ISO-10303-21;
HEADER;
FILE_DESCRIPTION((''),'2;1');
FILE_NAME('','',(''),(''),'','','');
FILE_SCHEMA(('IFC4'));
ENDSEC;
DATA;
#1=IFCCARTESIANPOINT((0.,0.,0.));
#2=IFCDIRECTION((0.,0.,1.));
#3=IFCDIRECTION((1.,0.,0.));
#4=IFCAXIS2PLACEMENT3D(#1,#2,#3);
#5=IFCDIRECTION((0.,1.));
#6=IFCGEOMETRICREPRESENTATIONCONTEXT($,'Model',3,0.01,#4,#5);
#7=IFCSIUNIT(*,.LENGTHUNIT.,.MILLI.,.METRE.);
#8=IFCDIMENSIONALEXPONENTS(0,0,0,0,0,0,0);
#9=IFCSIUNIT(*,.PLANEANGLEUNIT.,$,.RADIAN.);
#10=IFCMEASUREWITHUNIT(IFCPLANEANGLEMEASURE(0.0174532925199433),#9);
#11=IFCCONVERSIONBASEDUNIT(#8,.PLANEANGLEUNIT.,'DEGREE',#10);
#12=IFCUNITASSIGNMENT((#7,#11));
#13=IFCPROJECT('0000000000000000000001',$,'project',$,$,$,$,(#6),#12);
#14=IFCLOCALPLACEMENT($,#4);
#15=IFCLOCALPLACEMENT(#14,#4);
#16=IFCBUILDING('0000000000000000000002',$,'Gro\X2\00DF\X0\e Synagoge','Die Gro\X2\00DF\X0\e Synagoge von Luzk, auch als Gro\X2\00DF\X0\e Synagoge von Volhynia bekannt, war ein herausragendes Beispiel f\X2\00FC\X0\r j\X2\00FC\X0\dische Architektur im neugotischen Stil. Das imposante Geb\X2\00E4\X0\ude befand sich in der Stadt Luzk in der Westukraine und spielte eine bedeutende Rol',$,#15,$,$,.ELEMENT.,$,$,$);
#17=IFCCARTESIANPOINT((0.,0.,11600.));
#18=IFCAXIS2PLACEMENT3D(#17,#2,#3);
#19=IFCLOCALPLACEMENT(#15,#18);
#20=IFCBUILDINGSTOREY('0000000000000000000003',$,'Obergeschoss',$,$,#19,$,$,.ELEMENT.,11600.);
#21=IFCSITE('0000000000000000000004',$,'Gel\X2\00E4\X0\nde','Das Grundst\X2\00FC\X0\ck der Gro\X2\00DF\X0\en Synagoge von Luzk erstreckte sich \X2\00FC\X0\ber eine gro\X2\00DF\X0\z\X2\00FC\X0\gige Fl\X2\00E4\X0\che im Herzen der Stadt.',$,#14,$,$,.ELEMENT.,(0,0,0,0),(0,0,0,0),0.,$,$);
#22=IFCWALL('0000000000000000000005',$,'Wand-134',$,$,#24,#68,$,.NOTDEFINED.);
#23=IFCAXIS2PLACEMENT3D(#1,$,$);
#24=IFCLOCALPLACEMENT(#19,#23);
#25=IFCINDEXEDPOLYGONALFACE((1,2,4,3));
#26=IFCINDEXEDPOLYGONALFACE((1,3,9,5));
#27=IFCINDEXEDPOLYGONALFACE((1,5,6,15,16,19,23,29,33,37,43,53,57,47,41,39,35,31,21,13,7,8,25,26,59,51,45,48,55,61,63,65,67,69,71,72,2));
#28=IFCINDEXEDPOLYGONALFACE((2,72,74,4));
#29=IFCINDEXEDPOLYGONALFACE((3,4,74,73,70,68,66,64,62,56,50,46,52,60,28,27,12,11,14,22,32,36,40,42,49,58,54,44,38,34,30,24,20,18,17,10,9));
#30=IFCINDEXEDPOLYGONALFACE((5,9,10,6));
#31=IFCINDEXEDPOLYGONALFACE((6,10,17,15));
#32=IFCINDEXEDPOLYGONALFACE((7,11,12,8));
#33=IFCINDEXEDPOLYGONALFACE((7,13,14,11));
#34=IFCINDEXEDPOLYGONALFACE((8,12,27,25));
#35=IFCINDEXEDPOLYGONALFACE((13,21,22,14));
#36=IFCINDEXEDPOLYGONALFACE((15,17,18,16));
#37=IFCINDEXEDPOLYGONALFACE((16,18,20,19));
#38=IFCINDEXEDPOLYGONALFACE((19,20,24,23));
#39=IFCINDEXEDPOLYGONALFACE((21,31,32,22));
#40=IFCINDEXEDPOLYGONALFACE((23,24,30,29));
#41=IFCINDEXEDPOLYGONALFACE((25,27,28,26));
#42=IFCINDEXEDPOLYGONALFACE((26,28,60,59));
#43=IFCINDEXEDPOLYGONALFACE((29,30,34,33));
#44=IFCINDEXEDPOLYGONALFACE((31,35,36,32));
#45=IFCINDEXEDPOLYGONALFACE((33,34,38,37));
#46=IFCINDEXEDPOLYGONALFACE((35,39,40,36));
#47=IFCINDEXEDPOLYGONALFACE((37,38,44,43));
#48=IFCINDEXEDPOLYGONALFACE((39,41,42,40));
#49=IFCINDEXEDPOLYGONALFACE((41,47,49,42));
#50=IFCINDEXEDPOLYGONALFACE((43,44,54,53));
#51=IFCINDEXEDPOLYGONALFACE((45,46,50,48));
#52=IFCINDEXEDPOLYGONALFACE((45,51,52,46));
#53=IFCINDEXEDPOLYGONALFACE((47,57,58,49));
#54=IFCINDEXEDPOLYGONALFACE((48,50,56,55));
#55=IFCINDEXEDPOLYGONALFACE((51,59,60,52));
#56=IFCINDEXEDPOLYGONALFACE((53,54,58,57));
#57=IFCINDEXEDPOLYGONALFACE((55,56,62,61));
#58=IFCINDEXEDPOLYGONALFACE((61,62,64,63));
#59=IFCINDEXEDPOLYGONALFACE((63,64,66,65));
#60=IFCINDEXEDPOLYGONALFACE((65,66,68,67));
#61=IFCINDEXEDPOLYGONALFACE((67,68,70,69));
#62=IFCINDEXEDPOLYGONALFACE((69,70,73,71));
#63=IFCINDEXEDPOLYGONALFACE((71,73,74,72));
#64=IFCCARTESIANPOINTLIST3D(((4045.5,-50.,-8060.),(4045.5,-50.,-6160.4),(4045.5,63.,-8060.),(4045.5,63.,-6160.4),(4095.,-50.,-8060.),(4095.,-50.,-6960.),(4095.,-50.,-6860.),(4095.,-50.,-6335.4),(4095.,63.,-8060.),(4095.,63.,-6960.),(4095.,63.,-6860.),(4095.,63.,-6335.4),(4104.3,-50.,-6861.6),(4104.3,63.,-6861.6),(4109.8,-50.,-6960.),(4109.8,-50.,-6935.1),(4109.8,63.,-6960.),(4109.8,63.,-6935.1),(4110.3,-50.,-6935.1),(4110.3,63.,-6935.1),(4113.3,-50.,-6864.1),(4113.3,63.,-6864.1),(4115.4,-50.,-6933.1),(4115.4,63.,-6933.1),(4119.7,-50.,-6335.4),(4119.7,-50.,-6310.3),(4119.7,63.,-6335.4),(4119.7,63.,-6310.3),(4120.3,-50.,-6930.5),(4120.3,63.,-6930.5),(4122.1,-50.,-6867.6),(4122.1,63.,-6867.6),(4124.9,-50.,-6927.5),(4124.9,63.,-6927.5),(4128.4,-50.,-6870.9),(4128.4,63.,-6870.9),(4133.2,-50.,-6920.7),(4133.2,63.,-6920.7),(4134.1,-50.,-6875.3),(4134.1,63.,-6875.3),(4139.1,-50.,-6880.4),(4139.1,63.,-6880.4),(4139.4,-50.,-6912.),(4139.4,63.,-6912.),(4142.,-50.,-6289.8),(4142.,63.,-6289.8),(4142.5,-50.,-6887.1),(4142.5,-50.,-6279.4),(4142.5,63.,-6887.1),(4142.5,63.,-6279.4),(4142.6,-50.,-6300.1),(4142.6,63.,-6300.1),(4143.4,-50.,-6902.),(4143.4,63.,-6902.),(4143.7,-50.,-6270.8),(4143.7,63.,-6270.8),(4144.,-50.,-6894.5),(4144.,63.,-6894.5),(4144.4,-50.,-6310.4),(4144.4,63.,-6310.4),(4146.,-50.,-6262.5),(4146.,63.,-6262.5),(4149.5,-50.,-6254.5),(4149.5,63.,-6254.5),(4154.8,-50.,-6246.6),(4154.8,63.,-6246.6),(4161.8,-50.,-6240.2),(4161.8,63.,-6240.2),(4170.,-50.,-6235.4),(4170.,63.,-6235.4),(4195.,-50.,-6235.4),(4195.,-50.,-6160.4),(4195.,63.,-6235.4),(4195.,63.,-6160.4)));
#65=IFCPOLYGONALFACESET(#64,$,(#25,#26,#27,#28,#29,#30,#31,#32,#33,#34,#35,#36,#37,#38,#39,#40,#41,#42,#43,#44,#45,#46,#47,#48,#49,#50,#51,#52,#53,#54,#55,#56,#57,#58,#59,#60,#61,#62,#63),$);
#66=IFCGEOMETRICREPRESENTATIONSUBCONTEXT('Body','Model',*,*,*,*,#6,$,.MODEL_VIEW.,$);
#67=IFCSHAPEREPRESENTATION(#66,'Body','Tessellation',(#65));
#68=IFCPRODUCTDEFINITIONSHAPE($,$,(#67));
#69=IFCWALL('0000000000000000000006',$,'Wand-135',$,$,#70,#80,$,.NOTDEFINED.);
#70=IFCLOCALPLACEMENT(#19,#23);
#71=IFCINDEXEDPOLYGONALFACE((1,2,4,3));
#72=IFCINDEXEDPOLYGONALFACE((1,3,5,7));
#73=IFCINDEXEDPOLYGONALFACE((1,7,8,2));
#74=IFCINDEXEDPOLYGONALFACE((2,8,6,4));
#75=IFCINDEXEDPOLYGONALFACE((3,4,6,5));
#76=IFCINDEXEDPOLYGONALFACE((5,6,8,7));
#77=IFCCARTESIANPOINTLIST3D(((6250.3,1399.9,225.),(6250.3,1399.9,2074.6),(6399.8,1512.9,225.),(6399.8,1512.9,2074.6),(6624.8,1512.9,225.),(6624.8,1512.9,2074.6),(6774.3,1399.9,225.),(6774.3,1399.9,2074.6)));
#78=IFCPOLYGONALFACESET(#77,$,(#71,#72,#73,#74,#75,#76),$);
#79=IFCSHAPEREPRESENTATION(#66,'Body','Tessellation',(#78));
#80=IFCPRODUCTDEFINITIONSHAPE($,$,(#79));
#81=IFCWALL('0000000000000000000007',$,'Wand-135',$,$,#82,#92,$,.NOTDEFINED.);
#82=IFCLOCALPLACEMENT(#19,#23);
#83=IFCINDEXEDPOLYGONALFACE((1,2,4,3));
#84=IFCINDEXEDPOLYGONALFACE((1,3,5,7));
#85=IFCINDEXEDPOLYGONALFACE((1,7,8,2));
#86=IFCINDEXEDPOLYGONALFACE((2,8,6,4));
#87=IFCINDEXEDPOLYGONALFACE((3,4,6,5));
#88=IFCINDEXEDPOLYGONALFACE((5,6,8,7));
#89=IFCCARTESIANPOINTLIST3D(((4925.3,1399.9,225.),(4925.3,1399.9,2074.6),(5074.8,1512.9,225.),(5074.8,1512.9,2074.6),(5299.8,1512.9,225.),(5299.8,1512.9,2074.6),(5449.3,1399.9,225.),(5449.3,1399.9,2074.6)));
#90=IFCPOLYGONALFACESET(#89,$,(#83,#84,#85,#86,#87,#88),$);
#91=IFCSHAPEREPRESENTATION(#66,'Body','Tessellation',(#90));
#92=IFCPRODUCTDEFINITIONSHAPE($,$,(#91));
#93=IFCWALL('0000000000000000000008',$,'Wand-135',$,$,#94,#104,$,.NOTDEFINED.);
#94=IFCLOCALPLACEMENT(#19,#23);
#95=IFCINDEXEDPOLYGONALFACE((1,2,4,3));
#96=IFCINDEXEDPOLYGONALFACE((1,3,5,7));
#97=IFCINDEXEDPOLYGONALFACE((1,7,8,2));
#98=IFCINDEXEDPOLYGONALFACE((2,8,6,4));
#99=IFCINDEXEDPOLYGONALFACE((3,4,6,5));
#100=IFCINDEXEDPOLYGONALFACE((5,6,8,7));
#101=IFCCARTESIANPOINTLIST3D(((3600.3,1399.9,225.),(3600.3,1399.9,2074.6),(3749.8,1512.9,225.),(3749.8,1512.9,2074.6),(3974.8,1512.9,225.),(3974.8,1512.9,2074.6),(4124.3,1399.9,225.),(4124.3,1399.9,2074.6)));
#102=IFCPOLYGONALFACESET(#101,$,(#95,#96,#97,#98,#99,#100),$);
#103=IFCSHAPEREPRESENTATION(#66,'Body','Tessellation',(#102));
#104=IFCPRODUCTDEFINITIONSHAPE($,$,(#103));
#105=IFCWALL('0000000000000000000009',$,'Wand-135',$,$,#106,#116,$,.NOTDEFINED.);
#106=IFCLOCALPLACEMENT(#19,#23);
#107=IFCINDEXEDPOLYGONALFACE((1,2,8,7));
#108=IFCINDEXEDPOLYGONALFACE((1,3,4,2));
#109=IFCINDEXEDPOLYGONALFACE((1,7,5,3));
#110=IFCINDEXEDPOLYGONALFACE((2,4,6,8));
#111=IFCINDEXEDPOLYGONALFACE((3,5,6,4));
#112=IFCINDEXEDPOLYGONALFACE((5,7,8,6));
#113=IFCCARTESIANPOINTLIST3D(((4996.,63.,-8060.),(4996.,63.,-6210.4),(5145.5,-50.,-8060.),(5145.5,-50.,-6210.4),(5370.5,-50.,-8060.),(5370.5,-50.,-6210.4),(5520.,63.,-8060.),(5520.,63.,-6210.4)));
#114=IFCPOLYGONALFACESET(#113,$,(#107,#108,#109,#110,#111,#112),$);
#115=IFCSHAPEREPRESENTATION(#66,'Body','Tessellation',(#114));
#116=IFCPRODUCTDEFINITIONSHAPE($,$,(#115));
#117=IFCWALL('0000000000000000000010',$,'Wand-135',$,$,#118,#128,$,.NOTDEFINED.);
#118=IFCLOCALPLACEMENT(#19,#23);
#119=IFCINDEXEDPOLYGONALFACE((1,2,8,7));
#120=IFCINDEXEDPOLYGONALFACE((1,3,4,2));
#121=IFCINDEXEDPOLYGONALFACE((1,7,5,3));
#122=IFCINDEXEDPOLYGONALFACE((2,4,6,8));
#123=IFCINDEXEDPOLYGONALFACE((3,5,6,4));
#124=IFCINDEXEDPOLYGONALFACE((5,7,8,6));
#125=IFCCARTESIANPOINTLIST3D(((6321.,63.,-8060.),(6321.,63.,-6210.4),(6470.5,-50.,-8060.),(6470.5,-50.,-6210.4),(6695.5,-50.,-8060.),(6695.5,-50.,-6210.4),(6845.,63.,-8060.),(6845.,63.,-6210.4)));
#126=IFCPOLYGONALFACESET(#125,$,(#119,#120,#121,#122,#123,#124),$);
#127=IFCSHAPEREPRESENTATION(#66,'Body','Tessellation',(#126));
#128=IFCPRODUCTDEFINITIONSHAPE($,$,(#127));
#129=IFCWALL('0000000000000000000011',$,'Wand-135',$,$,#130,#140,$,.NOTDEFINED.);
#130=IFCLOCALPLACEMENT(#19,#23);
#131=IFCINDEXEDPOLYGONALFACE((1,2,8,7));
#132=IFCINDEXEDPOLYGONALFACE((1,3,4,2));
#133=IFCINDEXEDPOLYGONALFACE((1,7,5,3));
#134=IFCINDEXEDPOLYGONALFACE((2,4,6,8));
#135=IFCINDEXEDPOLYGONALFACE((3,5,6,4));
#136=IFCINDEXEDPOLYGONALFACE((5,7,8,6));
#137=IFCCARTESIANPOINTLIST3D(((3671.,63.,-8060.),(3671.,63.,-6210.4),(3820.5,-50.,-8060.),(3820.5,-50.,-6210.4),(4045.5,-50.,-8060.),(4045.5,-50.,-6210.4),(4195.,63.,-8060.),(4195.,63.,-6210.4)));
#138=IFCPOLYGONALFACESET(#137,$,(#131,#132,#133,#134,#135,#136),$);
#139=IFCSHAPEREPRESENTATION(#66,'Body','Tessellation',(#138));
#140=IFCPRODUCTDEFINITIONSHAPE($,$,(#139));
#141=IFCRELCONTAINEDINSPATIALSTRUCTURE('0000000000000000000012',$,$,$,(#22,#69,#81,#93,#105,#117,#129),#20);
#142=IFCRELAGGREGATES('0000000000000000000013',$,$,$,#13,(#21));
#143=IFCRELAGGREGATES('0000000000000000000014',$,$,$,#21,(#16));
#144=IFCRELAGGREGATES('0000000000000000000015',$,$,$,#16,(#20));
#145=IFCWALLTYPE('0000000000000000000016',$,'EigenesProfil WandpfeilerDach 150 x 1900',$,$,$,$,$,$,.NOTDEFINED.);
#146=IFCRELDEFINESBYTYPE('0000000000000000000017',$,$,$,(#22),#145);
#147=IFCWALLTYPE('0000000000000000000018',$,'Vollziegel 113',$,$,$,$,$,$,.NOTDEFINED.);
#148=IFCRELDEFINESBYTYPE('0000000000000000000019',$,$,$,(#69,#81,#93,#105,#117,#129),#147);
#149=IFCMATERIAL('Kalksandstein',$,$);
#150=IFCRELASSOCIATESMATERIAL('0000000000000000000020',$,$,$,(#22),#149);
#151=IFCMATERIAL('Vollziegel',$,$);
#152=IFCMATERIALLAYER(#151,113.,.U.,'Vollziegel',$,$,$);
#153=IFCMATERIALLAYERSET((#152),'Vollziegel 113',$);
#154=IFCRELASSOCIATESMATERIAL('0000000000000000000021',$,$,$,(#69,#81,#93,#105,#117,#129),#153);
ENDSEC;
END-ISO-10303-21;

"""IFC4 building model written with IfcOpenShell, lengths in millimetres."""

from ifc_helpers import new_model, entity, si_unit, converted_unit, direction, frame, origin_with_axes, place, context, subcontext, project, spatial, line, arc, indexed_curve, outline, extrude, material, layer, layer_set, layer_usage, material_profile, profile_set, type_object, element, save


model = new_model("IFC4")

# Units and contexts
model_context = context("Model", 3, precision=0.01, world=origin_with_axes(), true_north=direction((0.0, 1.0)))
body_context = subcontext(model_context, "Body", "Model", "MODEL_VIEW")
ifc_project = project(units=[si_unit("LENGTHUNIT", "METRE", prefix="MILLI"), converted_unit("PLANEANGLEUNIT", "DEGREE", entity("IfcPlaneAngleMeasure", 0.0174532925199433), si_unit("PLANEANGLEUNIT", "RADIAN"), dimensions=[0, 0, 0, 0, 0, 0, 0])], contexts=[model_context])

# Site, building, storey
site_placement = place(None, origin_with_axes())
site = spatial("IfcSite", under=ifc_project, at=site_placement, Name="Gelände", Description="Das Grundstück der Großen Synagoge von Luzk erstreckte sich über eine großzügige Fläche im Herzen der Stadt.", CompositionType="ELEMENT", RefLatitude=(0, 0, 0, 0), RefLongitude=(0, 0, 0, 0), RefElevation=0.0)
building_placement = place(site_placement, origin_with_axes())
building = spatial("IfcBuilding", under=site, at=building_placement, Name="Große Synagoge", Description="Die Große Synagoge von Luzk, auch als Große Synagoge von Volhynia bekannt, war ein herausragendes Beispiel für jüdische Architektur im neugotischen Stil. Das imposante Gebäude befand sich in der Stadt Luzk in der Westukraine und spielte eine bedeutende Rol", CompositionType="ELEMENT")
storey_placement = place(building_placement, frame((0.0, 0.0, 11600.0), z_axis=(0.0, 0.0, 1.0), x_axis=(1.0, 0.0, 0.0)))
storey = spatial("IfcBuildingStorey", under=building, at=storey_placement, Name="Obergeschoss", CompositionType="ELEMENT", Elevation=11600.0)

# Walls
ifc_material_1 = material(Name="Kalksandstein")
ifc_material_profile = material_profile(ifc_material_1, outline(indexed_curve([(74.2, 1749.6), (98.9, 1749.6), (96.7, 1765.0), (97.0, 1780.5), (99.2, 1793.4), (103.9, 1805.5), (112.6, 1816.7), (124.5, 1824.6), (149.5, 1824.6), (149.5, 1899.6), (0.0, 1899.6), (0.0, 0.0), (49.5, 0.0), (49.5, 1100.0), (64.3, 1100.0), (64.3, 1124.9), (64.8, 1124.9), (72.4, 1128.1), (79.4, 1132.4), (91.1, 1143.4), (97.9, 1157.9), (98.0, 1169.2), (93.5, 1179.5), (85.8, 1187.0), (76.6, 1192.3), (63.3, 1197.2), (49.5, 1200.0), (49.5, 1724.6), (74.2, 1724.6)], segments=[line(1, 2), arc(2, 3, 4), arc(4, 5, 6), arc(6, 7, 8), line(8, 9, 10, 11, 12, 13, 14, 15, 16, 17), arc(17, 18, 19), arc(19, 20, 21), arc(21, 22, 23), arc(23, 24, 25), arc(25, 26, 27), line(27, 28, 29, 1)])), Name="Kalksandstein")
ifc_profile_set = profile_set([ifc_material_profile], Name="EigenesProfil WandpfeilerDach")
wall_type_1 = type_object("IfcWallType", Name="EigenesProfil WandpfeilerDach 150 x 1900", PredefinedType="NOTDEFINED")
wall_1_placement = place(storey_placement, frame((4045.5, -50.0, -8060.0), z_axis=(0.0, 0.0, 1.0), x_axis=(0.0, 1.0, 0.0)))
element("IfcWall", 1, at=wall_1_placement, inside=storey, type_object=wall_type_1, material=ifc_profile_set, Name="Wand-134", PredefinedType="NOTDEFINED", context=body_context, shape_type="SweptSolid", body=[
    extrude(outline(indexed_curve([(74.2, 1749.6), (98.9, 1749.6), (96.7, 1765.0), (97.0, 1780.5), (99.2, 1793.4), (103.9, 1805.5), (112.6, 1816.7), (124.5, 1824.6), (149.5, 1824.6), (149.5, 1899.6), (0.0, 1899.6), (0.0, 0.0), (49.5, 0.0), (49.5, 1100.0), (64.3, 1100.0), (64.3, 1124.9), (64.8, 1124.9), (72.4, 1128.1), (79.4, 1132.4), (91.1, 1143.4), (97.9, 1157.9), (98.0, 1169.2), (93.5, 1179.5), (85.8, 1187.0), (76.6, 1192.3), (63.3, 1197.2), (49.5, 1200.0), (49.5, 1724.6), (74.2, 1724.6)], segments=[line(1, 2), arc(2, 3, 4), arc(4, 5, 6), arc(6, 7, 8), line(8, 9, 10, 11, 12, 13, 14, 15, 16, 17), arc(17, 18, 19), arc(19, 20, 21), arc(21, 22, 23), arc(23, 24, 25), arc(25, 26, 27), line(27, 28, 29, 1)])), frame((0.0, 0.0, 0.0), z_axis=(-1.0, 0.0, 0.0), x_axis=(0.0, -1.0, 0.0)), (0.0, 0.0, -1.0), 113.0),
])
ifc_material_2 = material(Name="Vollziegel")
ifc_layer = layer(ifc_material_2, 113.0, ventilated="UNKNOWN", Name="Vollziegel")
ifc_layer_set = layer_set([ifc_layer], Name="Vollziegel 113")
ifc_layer_usage_1 = layer_usage(ifc_layer_set, "AXIS2", "NEGATIVE", 113.0)
wall_type_2 = type_object("IfcWallType", Name="Vollziegel 113", PredefinedType="NOTDEFINED")
wall_2_placement = place(storey_placement, frame((6399.8, 1399.9, 225.0), z_axis=(0.0, 0.0, 1.0), x_axis=(1.0, 0.0, 0.0)))
element("IfcWall", 2, at=wall_2_placement, inside=storey, type_object=wall_type_2, material=ifc_layer_usage_1, Name="Wand-135", PredefinedType="NOTDEFINED", context=body_context, shape_type="SweptSolid", body=[
    extrude(outline(indexed_curve([(-149.5, 0.0), (374.5, 0.0), (225.0, 113.0), (0.0, 113.0)], segments=[line(1, 2, 3, 4, 1)])), origin_with_axes(), (0.0, 0.0, 1.0), 1849.6),
])
ifc_layer_usage_2 = layer_usage(ifc_layer_set, "AXIS2", "NEGATIVE", 113.0)
wall_3_placement = place(storey_placement, frame((5074.8, 1399.9, 225.0), z_axis=(0.0, 0.0, 1.0), x_axis=(1.0, 0.0, 0.0)))
element("IfcWall", 3, at=wall_3_placement, inside=storey, type_object=wall_type_2, material=ifc_layer_usage_2, Name="Wand-135", PredefinedType="NOTDEFINED", context=body_context, shape_type="SweptSolid", body=[
    extrude(outline(indexed_curve([(-149.5, 0.0), (374.5, 0.0), (225.0, 113.0), (0.0, 113.0)], segments=[line(1, 2, 3, 4, 1)])), origin_with_axes(), (0.0, 0.0, 1.0), 1849.6),
])
ifc_layer_usage_3 = layer_usage(ifc_layer_set, "AXIS2", "NEGATIVE", 113.0)
wall_4_placement = place(storey_placement, frame((3749.8, 1399.9, 225.0), z_axis=(0.0, 0.0, 1.0), x_axis=(1.0, 0.0, 0.0)))
element("IfcWall", 4, at=wall_4_placement, inside=storey, type_object=wall_type_2, material=ifc_layer_usage_3, Name="Wand-135", PredefinedType="NOTDEFINED", context=body_context, shape_type="SweptSolid", body=[
    extrude(outline(indexed_curve([(-149.5, 0.0), (374.5, 0.0), (225.0, 113.0), (0.0, 113.0)], segments=[line(1, 2, 3, 4, 1)])), origin_with_axes(), (0.0, 0.0, 1.0), 1849.6),
])
ifc_layer_usage_4 = layer_usage(ifc_layer_set, "AXIS2", "POSITIVE", -113.0)
wall_5_placement = place(storey_placement, frame((5145.5, 63.0, -8060.0), z_axis=(0.0, 0.0, 1.0), x_axis=(1.0, 0.0, 0.0)))
element("IfcWall", 5, at=wall_5_placement, inside=storey, type_object=wall_type_2, material=ifc_layer_usage_4, Name="Wand-135", PredefinedType="NOTDEFINED", context=body_context, shape_type="SweptSolid", body=[
    extrude(outline(indexed_curve([(0.0, -113.0), (225.0, -113.0), (374.5, 0.0), (-149.5, 0.0)], segments=[line(1, 2, 3, 4, 1)])), origin_with_axes(), (0.0, 0.0, 1.0), 1849.6),
])
ifc_layer_usage_5 = layer_usage(ifc_layer_set, "AXIS2", "POSITIVE", -113.0)
wall_6_placement = place(storey_placement, frame((6470.5, 63.0, -8060.0), z_axis=(0.0, 0.0, 1.0), x_axis=(1.0, 0.0, 0.0)))
element("IfcWall", 6, at=wall_6_placement, inside=storey, type_object=wall_type_2, material=ifc_layer_usage_5, Name="Wand-135", PredefinedType="NOTDEFINED", context=body_context, shape_type="SweptSolid", body=[
    extrude(outline(indexed_curve([(0.0, -113.0), (225.0, -113.0), (374.5, 0.0), (-149.5, 0.0)], segments=[line(1, 2, 3, 4, 1)])), origin_with_axes(), (0.0, 0.0, 1.0), 1849.6),
])
ifc_layer_usage_6 = layer_usage(ifc_layer_set, "AXIS2", "POSITIVE", -113.0)
wall_7_placement = place(storey_placement, frame((3820.5, 63.0, -8060.0), z_axis=(0.0, 0.0, 1.0), x_axis=(1.0, 0.0, 0.0)))
element("IfcWall", 7, at=wall_7_placement, inside=storey, type_object=wall_type_2, material=ifc_layer_usage_6, Name="Wand-135", PredefinedType="NOTDEFINED", context=body_context, shape_type="SweptSolid", body=[
    extrude(outline(indexed_curve([(0.0, -113.0), (225.0, -113.0), (374.5, 0.0), (-149.5, 0.0)], segments=[line(1, 2, 3, 4, 1)])), origin_with_axes(), (0.0, 0.0, 1.0), 1849.6),
])

save(model, "model.ifc")
